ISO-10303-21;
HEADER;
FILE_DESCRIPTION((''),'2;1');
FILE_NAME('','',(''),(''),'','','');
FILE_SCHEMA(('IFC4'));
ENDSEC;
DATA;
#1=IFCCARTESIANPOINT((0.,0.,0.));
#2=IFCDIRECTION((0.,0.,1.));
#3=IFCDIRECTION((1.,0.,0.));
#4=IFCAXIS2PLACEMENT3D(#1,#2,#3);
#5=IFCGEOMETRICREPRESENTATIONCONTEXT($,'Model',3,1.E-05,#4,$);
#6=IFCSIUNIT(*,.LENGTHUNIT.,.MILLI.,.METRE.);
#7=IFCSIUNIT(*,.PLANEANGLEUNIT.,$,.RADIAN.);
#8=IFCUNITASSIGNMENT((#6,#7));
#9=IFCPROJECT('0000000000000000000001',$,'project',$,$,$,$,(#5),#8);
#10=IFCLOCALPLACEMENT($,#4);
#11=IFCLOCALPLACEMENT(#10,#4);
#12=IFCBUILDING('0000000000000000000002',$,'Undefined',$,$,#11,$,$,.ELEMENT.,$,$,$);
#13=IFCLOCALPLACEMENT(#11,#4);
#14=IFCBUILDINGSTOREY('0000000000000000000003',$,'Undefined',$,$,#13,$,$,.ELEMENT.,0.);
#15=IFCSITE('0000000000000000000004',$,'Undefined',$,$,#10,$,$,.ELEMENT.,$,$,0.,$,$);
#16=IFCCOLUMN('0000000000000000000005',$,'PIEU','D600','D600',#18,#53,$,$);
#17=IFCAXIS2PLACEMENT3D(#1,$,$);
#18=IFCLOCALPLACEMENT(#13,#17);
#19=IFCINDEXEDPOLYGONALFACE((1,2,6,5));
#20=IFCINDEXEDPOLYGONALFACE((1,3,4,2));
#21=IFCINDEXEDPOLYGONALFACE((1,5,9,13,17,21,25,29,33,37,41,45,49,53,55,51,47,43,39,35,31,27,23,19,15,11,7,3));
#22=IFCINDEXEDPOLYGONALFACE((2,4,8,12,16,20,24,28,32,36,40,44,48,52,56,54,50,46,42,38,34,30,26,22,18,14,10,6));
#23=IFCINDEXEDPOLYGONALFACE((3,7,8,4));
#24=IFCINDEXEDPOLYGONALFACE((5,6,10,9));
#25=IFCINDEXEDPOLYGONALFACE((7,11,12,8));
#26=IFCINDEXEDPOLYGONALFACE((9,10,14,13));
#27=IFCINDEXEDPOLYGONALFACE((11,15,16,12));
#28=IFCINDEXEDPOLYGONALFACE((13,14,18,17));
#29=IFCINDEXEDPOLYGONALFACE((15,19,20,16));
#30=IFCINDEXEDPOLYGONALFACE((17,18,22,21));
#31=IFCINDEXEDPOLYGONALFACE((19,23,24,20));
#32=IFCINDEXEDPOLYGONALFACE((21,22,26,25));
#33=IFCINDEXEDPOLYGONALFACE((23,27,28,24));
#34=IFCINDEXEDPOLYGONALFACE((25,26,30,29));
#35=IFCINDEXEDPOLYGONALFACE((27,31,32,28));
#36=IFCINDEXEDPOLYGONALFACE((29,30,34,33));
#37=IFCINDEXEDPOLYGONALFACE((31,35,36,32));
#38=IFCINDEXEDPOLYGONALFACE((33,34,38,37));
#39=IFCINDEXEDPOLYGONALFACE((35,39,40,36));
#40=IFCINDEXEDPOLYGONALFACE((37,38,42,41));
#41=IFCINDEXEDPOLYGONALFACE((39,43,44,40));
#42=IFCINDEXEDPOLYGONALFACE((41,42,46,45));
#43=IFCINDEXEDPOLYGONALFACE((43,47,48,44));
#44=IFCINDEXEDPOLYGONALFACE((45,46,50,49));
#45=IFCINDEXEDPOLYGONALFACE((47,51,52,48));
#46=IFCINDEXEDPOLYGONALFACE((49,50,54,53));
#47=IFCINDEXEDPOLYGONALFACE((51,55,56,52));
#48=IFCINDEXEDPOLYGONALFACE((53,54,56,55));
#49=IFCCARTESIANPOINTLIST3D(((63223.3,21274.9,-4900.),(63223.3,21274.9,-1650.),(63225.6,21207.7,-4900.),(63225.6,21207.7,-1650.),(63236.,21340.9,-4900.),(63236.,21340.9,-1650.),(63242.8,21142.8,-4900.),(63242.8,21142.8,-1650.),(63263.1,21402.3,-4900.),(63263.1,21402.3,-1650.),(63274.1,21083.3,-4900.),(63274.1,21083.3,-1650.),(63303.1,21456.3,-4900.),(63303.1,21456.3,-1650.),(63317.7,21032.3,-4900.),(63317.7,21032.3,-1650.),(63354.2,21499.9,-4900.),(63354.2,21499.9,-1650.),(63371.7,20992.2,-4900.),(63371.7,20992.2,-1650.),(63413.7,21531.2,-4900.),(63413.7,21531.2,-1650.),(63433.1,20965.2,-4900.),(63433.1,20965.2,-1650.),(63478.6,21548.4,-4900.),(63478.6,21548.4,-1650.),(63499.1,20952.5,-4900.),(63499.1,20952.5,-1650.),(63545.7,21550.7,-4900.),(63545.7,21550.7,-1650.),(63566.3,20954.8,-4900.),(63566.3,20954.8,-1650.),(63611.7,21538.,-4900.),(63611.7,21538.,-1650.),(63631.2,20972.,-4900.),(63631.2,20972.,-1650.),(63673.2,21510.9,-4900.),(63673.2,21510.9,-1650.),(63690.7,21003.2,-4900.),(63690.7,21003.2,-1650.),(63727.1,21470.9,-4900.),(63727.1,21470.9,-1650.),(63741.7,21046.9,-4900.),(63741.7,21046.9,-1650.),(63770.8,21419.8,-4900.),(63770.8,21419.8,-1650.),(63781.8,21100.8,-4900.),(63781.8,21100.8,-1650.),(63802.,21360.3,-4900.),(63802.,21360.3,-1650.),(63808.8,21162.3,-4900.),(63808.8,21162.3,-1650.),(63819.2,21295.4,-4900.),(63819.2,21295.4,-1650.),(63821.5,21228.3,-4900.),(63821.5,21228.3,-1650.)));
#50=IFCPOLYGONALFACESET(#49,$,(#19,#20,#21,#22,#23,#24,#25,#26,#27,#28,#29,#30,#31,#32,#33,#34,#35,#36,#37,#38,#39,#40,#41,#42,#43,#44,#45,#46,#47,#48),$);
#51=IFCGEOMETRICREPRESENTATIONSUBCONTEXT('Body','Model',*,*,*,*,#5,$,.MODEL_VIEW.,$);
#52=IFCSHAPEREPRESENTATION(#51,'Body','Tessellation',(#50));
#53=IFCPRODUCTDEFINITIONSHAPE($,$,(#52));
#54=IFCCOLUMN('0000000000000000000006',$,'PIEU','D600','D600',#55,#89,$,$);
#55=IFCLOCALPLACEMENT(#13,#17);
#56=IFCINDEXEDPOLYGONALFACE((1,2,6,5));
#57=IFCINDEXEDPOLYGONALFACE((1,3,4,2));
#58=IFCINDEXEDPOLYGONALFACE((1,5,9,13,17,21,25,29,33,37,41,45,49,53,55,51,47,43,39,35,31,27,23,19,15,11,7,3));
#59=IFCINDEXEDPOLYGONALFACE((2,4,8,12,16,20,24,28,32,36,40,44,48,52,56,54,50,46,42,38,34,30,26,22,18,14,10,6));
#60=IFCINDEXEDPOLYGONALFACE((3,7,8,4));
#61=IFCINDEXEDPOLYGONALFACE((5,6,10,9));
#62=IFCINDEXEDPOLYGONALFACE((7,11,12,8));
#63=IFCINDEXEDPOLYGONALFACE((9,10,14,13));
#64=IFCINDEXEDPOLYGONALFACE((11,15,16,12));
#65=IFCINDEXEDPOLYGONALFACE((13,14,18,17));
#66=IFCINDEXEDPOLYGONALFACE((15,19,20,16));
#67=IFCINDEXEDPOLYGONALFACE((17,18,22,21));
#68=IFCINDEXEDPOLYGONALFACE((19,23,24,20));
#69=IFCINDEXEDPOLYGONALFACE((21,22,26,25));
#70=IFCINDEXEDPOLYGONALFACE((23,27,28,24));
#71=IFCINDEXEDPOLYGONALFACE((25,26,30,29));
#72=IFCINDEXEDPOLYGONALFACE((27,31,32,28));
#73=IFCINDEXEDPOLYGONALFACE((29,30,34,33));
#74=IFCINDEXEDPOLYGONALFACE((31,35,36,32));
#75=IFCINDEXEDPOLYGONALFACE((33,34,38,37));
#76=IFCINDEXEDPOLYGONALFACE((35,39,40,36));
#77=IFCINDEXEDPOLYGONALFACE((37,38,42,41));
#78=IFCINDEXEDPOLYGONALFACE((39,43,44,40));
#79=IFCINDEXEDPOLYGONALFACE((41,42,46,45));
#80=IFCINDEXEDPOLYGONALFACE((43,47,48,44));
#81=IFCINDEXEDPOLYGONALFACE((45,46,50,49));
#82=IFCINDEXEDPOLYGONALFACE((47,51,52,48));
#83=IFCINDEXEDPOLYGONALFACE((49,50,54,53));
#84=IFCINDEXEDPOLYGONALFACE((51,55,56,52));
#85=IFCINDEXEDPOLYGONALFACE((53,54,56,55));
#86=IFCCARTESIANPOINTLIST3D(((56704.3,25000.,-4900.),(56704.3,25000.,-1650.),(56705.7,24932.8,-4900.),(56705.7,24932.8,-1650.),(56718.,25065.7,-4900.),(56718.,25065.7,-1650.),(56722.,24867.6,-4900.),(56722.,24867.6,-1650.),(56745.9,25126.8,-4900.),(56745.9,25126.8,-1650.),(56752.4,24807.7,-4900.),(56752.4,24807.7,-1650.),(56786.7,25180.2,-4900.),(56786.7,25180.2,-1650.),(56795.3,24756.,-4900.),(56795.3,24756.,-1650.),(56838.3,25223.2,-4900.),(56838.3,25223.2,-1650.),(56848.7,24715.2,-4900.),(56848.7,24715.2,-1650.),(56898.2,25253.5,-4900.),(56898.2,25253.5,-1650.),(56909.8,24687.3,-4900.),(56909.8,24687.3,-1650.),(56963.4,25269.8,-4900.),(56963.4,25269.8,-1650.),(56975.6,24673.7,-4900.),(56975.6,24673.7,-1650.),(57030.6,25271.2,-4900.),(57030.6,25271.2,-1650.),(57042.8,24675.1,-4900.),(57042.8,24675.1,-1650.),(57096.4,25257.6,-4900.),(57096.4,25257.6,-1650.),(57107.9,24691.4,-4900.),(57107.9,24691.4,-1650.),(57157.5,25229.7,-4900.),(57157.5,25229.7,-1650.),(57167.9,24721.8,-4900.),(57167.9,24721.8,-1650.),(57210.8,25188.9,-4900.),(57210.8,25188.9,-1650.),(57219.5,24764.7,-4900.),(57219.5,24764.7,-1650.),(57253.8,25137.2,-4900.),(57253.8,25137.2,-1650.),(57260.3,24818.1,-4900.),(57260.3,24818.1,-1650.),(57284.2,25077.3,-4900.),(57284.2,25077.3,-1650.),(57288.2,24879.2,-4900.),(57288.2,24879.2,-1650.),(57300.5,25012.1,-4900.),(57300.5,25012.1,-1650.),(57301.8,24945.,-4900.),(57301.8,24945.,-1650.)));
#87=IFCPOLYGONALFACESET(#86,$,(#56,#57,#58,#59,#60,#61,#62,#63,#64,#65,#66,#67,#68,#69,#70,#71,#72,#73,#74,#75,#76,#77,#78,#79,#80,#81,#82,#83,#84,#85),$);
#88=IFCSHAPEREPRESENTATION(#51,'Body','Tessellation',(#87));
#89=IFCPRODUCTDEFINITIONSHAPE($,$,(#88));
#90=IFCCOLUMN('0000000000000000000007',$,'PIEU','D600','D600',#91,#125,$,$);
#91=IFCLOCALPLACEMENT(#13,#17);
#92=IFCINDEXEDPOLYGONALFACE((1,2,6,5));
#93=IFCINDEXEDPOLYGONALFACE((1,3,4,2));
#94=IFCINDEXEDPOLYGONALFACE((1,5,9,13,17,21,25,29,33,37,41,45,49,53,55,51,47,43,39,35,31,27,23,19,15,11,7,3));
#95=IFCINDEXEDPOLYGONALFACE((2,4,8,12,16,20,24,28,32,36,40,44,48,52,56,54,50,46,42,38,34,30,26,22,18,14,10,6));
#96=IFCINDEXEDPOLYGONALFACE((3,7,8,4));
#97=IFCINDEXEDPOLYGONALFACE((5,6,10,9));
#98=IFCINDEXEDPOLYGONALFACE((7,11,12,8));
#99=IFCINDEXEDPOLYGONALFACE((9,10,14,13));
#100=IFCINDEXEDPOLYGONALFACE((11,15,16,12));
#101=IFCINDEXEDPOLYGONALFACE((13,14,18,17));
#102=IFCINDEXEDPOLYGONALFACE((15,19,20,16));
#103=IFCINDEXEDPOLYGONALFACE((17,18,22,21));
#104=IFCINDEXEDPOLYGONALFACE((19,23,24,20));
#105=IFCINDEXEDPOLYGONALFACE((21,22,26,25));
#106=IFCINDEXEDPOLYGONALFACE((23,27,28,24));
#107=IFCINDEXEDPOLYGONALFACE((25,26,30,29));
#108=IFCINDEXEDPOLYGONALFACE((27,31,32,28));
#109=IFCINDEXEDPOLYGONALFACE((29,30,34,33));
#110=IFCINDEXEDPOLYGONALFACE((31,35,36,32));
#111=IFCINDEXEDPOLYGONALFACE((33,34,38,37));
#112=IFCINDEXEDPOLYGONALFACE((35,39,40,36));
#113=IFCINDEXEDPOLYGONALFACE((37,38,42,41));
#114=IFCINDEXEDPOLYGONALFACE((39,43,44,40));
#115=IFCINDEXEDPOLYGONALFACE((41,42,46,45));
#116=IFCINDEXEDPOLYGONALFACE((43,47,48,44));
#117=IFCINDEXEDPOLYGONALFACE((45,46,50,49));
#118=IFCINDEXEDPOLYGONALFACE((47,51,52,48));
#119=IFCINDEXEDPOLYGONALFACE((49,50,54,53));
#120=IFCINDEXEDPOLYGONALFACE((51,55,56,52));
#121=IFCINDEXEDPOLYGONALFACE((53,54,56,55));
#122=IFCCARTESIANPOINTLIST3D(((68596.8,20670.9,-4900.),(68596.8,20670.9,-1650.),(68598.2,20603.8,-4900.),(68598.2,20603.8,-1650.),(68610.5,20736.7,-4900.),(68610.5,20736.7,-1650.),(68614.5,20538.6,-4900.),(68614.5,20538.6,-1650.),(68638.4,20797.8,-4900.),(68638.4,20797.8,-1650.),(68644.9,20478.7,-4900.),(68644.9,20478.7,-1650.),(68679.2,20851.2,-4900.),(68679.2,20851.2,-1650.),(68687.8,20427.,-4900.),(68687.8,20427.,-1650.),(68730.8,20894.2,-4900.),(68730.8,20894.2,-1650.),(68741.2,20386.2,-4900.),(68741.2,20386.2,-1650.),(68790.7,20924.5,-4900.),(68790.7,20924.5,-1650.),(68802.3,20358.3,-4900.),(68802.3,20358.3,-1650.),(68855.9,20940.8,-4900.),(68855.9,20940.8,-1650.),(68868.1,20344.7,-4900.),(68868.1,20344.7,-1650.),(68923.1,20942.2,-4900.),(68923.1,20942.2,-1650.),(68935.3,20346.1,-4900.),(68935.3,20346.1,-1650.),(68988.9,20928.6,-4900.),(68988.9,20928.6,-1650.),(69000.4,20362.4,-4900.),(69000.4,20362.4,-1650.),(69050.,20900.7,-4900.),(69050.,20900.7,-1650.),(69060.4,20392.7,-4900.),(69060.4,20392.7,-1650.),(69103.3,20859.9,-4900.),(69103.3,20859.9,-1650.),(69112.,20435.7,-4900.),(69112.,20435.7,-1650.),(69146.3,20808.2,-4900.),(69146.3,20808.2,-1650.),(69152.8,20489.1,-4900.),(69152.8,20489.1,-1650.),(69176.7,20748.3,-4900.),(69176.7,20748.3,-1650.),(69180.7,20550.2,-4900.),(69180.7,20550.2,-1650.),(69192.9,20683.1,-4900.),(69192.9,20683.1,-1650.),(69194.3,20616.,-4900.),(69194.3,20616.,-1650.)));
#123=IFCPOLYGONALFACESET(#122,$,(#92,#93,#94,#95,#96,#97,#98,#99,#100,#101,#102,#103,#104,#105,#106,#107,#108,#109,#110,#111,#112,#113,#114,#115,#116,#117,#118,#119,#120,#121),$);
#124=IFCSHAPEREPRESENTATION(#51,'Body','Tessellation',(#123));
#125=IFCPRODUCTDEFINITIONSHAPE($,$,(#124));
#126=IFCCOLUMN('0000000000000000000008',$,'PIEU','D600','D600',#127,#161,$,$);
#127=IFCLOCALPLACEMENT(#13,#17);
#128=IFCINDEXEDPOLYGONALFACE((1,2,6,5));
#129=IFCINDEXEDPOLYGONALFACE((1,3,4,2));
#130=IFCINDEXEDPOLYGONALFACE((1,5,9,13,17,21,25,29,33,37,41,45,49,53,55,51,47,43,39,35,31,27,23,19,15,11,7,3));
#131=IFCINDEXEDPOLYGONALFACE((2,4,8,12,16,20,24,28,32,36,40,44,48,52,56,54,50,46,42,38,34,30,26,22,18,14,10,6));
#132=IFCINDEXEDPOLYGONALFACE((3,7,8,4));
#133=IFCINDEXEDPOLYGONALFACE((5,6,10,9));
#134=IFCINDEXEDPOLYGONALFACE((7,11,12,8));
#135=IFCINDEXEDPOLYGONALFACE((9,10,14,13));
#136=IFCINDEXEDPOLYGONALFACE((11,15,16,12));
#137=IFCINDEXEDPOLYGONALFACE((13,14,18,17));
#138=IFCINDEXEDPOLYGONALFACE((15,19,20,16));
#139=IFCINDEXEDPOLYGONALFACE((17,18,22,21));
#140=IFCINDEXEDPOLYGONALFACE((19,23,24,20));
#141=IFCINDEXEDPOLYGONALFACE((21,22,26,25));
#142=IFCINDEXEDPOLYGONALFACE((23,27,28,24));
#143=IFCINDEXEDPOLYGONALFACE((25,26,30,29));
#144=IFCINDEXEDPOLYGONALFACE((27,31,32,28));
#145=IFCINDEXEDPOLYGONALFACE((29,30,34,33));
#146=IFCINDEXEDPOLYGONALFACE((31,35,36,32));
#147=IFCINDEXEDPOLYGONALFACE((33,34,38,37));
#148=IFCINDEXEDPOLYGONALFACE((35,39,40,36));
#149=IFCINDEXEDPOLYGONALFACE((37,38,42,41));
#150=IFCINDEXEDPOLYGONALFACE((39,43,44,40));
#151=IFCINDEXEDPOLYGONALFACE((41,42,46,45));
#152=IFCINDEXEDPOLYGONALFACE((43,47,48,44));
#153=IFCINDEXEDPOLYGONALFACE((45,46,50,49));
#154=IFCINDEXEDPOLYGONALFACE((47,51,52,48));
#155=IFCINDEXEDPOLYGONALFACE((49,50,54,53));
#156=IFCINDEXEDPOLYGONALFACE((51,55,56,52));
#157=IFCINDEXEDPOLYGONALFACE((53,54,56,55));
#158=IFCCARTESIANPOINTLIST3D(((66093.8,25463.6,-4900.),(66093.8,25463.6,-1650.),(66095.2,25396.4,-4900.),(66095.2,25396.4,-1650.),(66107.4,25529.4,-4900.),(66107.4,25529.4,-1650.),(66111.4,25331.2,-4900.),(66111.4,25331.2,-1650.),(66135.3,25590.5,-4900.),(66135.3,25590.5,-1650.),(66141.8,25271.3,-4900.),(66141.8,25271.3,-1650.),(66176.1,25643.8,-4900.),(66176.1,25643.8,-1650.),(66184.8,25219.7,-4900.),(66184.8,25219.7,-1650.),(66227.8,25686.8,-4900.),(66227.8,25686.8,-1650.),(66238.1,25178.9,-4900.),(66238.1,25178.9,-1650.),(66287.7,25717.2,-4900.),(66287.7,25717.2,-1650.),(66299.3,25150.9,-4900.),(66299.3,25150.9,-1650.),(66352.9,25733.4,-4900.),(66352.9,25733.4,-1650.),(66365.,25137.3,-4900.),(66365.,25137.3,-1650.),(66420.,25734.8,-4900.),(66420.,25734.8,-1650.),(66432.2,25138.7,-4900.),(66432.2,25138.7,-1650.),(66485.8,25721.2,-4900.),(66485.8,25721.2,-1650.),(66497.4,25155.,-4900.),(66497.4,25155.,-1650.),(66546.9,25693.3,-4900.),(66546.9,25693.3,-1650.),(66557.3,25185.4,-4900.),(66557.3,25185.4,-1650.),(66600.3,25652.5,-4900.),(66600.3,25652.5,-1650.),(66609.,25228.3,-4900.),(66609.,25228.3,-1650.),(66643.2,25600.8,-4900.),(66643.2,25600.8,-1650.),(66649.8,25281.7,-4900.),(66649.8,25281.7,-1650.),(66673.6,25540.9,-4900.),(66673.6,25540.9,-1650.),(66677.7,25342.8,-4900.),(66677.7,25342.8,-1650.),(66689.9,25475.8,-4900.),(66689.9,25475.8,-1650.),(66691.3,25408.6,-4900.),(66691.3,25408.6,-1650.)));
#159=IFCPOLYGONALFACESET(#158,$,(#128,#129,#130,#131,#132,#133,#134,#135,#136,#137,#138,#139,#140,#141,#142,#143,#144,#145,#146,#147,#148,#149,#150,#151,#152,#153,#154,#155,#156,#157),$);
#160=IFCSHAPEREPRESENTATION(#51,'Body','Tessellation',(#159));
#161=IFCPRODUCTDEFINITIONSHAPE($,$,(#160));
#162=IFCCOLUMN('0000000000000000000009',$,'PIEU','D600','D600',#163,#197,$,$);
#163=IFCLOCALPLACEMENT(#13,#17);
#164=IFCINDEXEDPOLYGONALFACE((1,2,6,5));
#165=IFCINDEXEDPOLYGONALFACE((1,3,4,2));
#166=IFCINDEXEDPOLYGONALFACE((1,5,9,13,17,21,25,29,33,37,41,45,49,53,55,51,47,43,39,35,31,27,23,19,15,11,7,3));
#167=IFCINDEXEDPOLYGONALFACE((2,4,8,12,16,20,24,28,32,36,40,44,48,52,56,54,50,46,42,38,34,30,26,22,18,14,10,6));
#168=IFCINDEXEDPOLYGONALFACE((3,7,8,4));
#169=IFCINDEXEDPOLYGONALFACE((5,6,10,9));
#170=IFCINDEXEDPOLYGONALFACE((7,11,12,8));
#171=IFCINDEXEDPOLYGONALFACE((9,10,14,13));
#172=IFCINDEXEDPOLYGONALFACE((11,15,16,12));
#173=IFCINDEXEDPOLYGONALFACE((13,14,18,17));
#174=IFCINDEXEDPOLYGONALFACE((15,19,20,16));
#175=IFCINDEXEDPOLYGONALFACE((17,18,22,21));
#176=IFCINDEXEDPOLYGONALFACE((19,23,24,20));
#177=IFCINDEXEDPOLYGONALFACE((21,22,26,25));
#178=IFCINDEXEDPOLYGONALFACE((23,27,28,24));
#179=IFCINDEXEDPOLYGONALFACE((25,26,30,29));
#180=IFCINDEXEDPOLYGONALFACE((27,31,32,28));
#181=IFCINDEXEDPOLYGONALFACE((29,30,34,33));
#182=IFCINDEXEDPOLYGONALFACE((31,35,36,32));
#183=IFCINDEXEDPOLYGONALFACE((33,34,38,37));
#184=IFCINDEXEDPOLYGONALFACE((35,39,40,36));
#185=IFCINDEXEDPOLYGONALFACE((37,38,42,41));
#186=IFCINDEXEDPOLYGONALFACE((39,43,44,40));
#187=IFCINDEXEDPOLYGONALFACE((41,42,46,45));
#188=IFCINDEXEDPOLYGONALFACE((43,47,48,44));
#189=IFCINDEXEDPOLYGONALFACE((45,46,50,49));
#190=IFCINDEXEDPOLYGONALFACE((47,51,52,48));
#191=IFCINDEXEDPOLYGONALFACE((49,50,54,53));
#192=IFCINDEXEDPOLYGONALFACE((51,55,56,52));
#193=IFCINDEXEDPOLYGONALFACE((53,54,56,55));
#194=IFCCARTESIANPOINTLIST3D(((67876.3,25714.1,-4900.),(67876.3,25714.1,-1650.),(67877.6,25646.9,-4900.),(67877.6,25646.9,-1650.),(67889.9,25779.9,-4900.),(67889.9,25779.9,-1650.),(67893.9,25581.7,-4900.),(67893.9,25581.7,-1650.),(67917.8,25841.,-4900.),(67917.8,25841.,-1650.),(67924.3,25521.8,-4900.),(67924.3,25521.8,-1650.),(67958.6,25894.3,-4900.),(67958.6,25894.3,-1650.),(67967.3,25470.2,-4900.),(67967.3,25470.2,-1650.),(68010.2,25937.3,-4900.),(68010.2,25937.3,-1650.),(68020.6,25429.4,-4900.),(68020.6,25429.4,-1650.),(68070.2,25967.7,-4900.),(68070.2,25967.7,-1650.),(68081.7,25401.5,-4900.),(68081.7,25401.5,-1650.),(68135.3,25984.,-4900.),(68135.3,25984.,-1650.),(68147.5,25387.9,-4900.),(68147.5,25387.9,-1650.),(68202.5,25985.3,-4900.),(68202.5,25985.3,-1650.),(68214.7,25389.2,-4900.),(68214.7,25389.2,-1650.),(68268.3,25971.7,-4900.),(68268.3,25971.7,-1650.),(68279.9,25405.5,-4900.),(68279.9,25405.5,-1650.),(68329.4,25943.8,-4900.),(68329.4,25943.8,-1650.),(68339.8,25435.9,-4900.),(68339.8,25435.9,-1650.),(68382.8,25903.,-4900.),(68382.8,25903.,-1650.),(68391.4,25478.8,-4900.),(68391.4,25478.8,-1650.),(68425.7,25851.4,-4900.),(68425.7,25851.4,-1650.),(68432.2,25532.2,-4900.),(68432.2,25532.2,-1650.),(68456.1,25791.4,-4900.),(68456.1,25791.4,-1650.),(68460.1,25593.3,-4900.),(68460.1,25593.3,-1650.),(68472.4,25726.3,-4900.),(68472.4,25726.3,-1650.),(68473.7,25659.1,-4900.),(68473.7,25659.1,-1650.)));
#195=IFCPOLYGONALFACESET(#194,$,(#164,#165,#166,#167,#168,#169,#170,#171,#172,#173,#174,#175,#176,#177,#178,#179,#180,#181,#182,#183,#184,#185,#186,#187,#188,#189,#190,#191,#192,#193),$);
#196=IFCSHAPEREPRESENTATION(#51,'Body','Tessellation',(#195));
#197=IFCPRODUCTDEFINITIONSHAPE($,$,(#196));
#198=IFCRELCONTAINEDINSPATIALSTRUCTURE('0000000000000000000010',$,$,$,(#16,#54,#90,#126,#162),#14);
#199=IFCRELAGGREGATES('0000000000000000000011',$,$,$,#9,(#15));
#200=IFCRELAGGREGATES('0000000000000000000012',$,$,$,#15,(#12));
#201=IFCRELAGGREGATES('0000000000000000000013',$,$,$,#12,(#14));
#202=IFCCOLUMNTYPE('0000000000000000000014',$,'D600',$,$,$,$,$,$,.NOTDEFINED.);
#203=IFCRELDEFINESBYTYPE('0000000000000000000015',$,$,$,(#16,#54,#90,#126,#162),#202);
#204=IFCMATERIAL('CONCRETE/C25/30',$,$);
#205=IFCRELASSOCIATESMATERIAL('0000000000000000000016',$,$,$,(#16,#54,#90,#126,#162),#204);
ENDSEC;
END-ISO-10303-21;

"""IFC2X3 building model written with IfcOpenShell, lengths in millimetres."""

from ifc_helpers import new_model, si_unit, frame, origin_with_axes, origin_2d_with_axis, place, context, subcontext, project, spatial, circle, extrude, material, type_object, element, save


model = new_model("IFC2X3")

# Units and contexts
model_context = context("Model", 3, precision=1e-05, world=origin_with_axes())
body_context = subcontext(model_context, "Body", "Model", "MODEL_VIEW")
ifc_project = project(units=[si_unit("LENGTHUNIT", "METRE", prefix="MILLI"), si_unit("PLANEANGLEUNIT", "RADIAN")], contexts=[model_context])

# Site, building, storey
site_placement = place(None, origin_with_axes())
site = spatial("IfcSite", under=ifc_project, at=site_placement, Name="Undefined", CompositionType="ELEMENT", RefElevation=0.0)
building_placement = place(site_placement, origin_with_axes())
building = spatial("IfcBuilding", under=site, at=building_placement, Name="Undefined", CompositionType="ELEMENT")
storey_placement = place(building_placement, origin_with_axes())
storey = spatial("IfcBuildingStorey", under=building, at=storey_placement, Name="Undefined", CompositionType="ELEMENT", Elevation=0.0)

# Columns
ifc_material_1 = material(Name="CONCRETE/C25/30")
column_type_1 = type_object("IfcColumnType", Name="D600", PredefinedType="NOTDEFINED")
for number, where, z_axis, x_axis, name in (
    (1, (63522.4, 21251.6, -4900.0), (0.0, 0.0, 1.0), (1.0, 0.0, 0.0), "PIEU"),
):
    element("IfcColumn", number, at=place(storey_placement, frame(where, z_axis=z_axis, x_axis=x_axis)), inside=storey, type_object=column_type_1, material=ifc_material_1, Name=name, Description="D600", ObjectType="D600", context=body_context, shape_type="SweptSolid", body=[
        extrude(circle(Radius=300.0, at=origin_2d_with_axis()), frame((0.0, 0.0, 3250.0), z_axis=(0.0, 0.0, -1.0), x_axis=(0.146083, -0.989272, 0.0)), (0.0, 0.0, 1.0), 3250.0),
    ])
column_1_placement = place(storey_placement, frame((57003.1, 24972.5, -4900.0), z_axis=(0.0, 0.0, 1.0), x_axis=(1.0, 0.0, 0.0)))
element("IfcColumn", 2, at=column_1_placement, inside=storey, type_object=column_type_1, material=ifc_material_1, Name="PIEU", Description="D600", ObjectType="D600", context=body_context, shape_type="SweptSolid", body=[
    extrude(circle(Radius=300.0, at=origin_2d_with_axis()), frame((0.0, 0.0, 3250.0), z_axis=(0.0, 0.0, -1.0), x_axis=(0.991216, 0.132256, 0.0)), (0.0, 0.0, 1.0), 3250.0),
])
for number, where, z_axis, x_axis, name in (
    (3, (68895.6, 20643.4, -4900.0), (0.0, 0.0, 1.0), (1.0, 0.0, 0.0), "PIEU"),
    (4, (66392.5, 25436.1, -4900.0), (0.0, 0.0, 1.0), (1.0, 0.0, 0.0), "PIEU"),
    (5, (68175.0, 25686.6, -4900.0), (0.0, 0.0, 1.0), (1.0, 0.0, 0.0), "PIEU"),
):
    element("IfcColumn", number, at=place(storey_placement, frame(where, z_axis=z_axis, x_axis=x_axis)), inside=storey, type_object=column_type_1, material=ifc_material_1, Name=name, Description="D600", ObjectType="D600", context=body_context, shape_type="SweptSolid", body=[
        extrude(circle(Radius=300.0, at=origin_2d_with_axis()), frame((0.0, 0.0, 3250.0), z_axis=(0.0, 0.0, -1.0), x_axis=(-0.132256, 0.991216, 0.0)), (0.0, 0.0, 1.0), 3250.0),
    ])

save(model, "model.ifc")
